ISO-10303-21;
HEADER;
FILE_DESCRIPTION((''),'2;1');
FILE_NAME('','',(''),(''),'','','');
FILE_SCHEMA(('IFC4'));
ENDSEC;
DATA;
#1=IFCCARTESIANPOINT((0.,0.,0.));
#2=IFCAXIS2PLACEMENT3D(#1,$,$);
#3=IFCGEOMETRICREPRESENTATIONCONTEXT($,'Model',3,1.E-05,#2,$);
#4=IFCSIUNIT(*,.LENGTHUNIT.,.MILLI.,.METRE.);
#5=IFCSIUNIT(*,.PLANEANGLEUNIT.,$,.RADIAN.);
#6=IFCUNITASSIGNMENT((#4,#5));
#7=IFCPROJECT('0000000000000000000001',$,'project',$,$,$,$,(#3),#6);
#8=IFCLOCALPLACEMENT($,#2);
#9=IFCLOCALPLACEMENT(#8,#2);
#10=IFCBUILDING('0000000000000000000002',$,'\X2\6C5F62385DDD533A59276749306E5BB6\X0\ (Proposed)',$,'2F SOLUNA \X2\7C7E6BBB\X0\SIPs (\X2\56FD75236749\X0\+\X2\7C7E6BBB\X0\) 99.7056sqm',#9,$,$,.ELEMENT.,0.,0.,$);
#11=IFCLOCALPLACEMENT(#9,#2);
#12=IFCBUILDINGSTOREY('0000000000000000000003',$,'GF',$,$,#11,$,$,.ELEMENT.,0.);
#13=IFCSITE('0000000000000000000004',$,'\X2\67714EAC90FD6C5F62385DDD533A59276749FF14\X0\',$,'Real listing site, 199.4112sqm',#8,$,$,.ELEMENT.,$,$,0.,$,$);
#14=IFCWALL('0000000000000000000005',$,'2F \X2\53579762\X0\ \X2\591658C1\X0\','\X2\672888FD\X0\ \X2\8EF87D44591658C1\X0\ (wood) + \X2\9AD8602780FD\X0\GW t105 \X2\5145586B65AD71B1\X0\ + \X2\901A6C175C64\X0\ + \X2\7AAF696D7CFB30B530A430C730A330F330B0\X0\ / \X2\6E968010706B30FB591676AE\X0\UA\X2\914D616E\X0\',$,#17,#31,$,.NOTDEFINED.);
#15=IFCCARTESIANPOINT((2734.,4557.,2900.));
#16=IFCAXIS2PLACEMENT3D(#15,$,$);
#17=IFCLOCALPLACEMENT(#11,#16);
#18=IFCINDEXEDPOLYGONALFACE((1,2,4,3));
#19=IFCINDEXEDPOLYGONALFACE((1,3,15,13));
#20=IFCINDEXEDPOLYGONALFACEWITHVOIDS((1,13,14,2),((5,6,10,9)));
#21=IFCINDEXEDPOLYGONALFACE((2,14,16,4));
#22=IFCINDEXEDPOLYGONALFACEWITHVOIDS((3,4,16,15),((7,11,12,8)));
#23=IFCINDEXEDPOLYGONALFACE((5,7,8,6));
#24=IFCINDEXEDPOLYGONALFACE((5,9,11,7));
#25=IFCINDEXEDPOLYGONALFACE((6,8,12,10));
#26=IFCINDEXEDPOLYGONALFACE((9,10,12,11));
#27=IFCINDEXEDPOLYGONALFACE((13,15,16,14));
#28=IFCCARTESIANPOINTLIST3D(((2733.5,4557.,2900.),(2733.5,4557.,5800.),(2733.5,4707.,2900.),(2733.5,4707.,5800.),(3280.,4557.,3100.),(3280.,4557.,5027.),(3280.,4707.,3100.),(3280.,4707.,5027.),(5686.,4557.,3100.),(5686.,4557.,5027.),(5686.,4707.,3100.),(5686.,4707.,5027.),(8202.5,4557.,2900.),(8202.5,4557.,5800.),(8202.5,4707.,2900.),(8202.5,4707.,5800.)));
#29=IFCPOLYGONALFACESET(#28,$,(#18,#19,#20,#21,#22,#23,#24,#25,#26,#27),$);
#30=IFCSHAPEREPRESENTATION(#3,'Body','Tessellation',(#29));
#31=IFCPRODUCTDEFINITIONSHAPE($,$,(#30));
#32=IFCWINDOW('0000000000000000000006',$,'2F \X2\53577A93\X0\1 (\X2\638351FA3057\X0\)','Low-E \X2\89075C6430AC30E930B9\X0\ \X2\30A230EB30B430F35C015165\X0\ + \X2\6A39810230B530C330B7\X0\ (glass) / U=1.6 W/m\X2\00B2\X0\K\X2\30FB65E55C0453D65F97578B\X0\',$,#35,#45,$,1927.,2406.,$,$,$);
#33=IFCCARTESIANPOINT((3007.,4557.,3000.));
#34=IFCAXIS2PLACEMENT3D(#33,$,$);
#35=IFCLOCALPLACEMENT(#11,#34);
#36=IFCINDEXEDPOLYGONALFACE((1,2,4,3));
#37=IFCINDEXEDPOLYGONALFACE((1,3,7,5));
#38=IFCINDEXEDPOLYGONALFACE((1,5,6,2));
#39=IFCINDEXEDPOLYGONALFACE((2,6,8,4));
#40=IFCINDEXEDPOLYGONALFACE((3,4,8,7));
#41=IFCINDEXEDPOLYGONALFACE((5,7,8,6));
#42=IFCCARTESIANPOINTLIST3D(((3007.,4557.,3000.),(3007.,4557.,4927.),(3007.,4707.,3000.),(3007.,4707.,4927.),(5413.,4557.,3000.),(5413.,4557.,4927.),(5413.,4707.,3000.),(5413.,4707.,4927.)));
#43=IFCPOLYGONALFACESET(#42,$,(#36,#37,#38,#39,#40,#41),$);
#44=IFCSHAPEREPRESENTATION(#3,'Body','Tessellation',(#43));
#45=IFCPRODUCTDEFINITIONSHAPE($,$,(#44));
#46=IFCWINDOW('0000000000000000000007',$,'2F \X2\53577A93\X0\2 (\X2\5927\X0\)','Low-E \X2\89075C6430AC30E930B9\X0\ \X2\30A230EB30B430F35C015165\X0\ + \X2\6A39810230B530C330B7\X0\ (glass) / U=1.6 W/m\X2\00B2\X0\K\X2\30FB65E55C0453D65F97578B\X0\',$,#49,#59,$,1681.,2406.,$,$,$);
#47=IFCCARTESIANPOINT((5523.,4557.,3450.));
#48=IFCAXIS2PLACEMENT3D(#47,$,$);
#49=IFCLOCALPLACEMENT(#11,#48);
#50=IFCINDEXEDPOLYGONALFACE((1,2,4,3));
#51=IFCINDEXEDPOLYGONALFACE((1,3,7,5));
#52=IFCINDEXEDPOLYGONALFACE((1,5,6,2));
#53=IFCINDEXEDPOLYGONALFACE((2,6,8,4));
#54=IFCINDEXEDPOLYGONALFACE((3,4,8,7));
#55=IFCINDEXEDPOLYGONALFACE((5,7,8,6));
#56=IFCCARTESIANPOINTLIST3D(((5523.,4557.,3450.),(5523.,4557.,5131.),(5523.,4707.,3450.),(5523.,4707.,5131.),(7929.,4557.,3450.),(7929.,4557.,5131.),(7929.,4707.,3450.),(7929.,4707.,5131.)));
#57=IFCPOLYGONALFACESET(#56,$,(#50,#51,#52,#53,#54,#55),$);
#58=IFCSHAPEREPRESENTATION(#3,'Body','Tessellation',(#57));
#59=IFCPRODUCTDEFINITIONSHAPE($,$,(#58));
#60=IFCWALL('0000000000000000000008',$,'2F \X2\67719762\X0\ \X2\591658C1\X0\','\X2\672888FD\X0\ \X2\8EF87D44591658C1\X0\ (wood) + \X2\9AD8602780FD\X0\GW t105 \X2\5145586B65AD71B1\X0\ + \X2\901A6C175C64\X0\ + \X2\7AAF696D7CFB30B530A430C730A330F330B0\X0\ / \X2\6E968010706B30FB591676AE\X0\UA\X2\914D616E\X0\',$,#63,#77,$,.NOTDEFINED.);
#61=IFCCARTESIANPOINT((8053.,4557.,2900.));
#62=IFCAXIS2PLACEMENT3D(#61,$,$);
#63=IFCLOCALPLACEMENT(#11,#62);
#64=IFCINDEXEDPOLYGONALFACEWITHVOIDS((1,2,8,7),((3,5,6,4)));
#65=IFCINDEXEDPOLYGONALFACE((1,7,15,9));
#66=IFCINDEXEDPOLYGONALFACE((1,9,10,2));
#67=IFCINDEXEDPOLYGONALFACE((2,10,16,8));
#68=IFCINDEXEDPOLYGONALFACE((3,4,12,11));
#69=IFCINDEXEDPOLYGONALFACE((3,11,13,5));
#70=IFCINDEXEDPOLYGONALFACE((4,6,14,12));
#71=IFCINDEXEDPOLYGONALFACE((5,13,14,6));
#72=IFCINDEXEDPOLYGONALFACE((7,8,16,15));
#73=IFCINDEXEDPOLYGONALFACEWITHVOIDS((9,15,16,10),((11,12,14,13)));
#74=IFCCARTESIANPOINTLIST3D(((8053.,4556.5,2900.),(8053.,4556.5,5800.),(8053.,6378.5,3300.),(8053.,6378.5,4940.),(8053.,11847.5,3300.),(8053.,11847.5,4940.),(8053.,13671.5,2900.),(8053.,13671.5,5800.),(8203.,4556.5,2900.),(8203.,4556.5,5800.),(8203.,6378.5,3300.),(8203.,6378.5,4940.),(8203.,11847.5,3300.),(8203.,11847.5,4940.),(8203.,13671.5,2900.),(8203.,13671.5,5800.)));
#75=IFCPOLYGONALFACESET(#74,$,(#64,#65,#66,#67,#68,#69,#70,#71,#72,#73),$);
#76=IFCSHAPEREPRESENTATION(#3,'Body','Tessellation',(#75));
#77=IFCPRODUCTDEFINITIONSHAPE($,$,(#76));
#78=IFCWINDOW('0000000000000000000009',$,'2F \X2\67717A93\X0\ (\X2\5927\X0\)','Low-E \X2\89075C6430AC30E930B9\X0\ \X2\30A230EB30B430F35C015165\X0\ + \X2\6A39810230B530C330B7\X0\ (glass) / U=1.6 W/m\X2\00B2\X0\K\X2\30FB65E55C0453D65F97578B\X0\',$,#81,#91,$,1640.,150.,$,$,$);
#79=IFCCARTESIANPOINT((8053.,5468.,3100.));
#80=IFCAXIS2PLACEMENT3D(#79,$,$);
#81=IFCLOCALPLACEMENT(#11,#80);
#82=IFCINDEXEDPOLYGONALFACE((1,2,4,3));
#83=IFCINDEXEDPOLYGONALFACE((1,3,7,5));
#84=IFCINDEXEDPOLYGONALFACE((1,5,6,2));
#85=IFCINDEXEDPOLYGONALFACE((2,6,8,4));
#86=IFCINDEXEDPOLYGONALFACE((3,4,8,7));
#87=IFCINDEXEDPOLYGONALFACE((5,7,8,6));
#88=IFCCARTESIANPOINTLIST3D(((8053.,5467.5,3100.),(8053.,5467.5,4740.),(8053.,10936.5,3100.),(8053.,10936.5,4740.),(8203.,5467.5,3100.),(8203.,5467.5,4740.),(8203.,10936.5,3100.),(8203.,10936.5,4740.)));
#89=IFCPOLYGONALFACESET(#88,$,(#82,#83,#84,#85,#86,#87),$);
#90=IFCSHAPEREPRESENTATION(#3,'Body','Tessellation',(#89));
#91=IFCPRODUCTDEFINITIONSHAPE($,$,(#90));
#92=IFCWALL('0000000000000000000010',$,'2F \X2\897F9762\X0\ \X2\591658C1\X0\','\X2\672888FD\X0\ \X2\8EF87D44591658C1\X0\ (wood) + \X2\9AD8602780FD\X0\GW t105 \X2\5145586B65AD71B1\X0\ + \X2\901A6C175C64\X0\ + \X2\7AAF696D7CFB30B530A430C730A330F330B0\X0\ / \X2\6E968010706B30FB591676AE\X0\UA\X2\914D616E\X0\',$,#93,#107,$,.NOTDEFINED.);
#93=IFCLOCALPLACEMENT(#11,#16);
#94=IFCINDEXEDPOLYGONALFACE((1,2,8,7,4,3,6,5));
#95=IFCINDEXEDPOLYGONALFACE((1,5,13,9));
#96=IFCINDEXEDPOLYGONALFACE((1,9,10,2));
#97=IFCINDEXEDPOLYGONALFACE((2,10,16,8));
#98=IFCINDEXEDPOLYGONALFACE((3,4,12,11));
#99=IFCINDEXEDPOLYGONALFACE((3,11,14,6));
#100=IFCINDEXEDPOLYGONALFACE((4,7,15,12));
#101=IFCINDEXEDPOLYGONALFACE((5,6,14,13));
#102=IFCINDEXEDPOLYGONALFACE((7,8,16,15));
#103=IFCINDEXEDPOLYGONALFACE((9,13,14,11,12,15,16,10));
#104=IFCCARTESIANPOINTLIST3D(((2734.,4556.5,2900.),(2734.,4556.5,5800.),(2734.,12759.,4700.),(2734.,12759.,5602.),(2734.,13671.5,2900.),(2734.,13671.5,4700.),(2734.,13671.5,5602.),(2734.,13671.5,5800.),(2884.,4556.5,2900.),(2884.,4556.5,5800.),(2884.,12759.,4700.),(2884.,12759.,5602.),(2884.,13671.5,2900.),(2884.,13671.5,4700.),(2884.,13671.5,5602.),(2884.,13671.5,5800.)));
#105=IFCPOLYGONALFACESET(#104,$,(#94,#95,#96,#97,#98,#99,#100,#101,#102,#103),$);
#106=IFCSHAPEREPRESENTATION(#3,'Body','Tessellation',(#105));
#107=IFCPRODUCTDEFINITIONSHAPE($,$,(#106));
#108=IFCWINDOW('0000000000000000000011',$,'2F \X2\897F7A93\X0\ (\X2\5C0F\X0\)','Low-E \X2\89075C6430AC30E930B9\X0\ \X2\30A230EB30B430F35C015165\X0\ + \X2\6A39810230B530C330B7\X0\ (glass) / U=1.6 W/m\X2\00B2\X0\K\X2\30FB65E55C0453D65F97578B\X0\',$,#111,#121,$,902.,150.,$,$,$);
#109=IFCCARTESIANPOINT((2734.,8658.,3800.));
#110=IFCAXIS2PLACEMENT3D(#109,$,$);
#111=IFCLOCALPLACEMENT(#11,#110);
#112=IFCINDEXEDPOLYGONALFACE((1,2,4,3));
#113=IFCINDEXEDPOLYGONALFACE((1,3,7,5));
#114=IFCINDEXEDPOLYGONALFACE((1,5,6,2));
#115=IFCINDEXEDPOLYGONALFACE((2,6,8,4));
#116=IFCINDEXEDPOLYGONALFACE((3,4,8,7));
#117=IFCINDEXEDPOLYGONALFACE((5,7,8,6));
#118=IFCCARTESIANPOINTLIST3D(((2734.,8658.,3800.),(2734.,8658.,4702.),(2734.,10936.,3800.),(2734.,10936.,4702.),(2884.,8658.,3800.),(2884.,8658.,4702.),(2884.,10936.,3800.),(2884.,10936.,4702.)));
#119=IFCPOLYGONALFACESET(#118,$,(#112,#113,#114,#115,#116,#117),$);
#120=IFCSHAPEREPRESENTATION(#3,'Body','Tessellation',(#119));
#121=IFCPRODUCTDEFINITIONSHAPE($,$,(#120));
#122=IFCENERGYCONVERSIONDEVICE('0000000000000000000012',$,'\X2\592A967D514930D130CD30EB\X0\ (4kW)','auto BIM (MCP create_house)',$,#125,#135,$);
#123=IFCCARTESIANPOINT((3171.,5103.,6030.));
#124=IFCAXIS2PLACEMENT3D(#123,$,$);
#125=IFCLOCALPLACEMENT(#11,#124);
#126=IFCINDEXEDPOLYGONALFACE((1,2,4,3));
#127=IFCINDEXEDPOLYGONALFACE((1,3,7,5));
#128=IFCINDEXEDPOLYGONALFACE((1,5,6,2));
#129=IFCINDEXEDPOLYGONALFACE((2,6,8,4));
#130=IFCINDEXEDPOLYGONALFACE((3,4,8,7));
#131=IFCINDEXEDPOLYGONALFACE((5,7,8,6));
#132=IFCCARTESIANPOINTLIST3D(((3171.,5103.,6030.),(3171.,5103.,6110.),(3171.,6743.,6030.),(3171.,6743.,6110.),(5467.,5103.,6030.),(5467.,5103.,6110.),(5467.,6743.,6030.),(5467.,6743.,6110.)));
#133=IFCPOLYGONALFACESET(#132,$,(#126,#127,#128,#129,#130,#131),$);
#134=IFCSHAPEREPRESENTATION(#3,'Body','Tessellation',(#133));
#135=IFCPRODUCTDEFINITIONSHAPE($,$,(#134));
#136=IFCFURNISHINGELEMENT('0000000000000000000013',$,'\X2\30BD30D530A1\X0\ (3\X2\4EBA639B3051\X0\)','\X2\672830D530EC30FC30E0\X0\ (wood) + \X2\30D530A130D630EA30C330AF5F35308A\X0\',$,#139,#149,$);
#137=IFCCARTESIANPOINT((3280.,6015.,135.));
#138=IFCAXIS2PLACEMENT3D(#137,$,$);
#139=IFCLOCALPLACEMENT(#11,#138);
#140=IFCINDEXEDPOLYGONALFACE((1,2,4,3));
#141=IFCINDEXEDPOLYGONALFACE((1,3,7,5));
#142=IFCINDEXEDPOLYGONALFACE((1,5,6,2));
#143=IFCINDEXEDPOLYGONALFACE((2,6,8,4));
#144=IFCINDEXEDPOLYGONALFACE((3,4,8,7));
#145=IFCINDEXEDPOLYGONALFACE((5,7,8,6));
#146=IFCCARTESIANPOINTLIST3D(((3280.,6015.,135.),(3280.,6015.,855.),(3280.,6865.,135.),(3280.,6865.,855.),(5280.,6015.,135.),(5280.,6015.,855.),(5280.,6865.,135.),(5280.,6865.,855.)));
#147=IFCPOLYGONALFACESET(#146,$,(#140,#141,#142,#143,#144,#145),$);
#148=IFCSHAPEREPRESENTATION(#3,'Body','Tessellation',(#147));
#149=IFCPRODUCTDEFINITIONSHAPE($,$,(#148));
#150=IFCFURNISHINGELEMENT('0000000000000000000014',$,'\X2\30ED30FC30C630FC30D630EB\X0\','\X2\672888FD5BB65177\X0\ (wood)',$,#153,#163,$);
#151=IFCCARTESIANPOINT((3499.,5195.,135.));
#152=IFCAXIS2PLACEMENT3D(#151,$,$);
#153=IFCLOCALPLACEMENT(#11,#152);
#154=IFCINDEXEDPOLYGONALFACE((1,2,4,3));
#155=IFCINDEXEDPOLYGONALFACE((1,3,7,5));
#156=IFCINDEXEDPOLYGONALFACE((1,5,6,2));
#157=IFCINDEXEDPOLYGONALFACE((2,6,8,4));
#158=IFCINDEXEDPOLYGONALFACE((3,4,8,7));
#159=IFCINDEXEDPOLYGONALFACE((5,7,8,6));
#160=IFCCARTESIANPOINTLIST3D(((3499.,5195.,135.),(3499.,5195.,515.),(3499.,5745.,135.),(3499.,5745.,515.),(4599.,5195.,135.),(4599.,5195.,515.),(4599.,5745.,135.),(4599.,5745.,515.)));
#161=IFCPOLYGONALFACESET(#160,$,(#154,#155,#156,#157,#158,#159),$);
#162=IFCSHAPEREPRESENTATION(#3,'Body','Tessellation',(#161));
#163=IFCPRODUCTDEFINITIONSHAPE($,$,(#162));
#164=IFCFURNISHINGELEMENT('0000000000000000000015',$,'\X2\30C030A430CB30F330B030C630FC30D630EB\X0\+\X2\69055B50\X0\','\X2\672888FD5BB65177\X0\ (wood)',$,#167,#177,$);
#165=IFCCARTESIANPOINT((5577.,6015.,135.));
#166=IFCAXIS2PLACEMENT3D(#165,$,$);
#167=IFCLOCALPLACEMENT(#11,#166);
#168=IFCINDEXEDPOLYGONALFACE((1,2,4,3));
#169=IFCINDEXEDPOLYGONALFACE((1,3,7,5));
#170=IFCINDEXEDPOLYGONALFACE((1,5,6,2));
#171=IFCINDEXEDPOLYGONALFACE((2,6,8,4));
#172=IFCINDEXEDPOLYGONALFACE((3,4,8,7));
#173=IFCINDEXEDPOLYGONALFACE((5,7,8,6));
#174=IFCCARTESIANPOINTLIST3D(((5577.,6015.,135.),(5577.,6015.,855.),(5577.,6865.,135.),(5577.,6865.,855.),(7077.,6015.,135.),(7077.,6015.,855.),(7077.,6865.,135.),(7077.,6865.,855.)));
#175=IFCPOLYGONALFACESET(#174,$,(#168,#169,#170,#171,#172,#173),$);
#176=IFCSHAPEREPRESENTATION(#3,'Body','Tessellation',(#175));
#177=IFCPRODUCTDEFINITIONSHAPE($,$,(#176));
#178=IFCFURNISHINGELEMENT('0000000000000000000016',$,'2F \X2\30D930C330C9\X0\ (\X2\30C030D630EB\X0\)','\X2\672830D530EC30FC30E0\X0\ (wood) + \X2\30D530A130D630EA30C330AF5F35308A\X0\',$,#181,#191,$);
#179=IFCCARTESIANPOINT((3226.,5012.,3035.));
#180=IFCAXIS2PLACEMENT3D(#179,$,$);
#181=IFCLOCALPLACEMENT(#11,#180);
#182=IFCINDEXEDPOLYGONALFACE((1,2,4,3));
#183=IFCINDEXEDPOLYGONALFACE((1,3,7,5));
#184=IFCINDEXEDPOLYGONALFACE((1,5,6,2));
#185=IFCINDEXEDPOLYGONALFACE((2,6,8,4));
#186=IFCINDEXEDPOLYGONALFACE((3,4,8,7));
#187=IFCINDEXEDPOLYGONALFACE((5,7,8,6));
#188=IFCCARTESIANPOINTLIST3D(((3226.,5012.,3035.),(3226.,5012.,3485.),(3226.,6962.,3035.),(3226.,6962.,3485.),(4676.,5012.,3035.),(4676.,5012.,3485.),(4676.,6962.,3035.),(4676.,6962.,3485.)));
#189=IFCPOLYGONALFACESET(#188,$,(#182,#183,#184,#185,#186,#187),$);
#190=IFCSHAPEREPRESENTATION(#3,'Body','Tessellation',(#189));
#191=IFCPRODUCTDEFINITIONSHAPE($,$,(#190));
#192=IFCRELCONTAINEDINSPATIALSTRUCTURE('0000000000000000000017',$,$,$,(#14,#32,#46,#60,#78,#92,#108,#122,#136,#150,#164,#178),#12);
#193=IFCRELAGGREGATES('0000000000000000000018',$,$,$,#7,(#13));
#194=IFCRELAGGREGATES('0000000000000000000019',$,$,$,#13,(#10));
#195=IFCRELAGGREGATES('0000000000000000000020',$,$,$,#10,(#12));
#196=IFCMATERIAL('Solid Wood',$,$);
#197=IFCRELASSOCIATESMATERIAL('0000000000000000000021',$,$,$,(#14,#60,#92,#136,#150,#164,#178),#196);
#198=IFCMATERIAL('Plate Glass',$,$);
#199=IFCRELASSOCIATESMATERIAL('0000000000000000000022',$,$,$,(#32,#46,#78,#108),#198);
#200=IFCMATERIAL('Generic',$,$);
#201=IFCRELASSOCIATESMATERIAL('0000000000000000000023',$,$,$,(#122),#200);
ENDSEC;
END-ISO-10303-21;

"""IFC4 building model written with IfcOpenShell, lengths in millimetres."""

from ifc_helpers import new_model, si_unit, frame, frame_2d, origin, place, context, project, spatial, rectangle, extrude, material, element, fill, save


model = new_model("IFC4")

# Units and contexts
model_context = context("Model", 3, precision=1e-05, world=origin())
ifc_project = project(units=[si_unit("LENGTHUNIT", "METRE", prefix="MILLI"), si_unit("PLANEANGLEUNIT", "RADIAN")], contexts=[model_context])

# Site, building, storey
site_placement = place(None, origin())
site = spatial("IfcSite", under=ifc_project, at=site_placement, Name="東京都江戸川区大杉４", ObjectType="Real listing site, 199.4112sqm", CompositionType="ELEMENT", RefElevation=0.0)
building_placement = place(site_placement, origin())
building = spatial("IfcBuilding", under=site, at=building_placement, Name="江戸川区大杉の家 (Proposed)", ObjectType="2F SOLUNA 籾殻SIPs (国産杉+籾殻) 99.7056sqm", CompositionType="ELEMENT", ElevationOfRefHeight=0.0, ElevationOfTerrain=0.0)
storey_placement = place(building_placement, origin())
storey = spatial("IfcBuildingStorey", under=building, at=storey_placement, Name="GF", CompositionType="ELEMENT", Elevation=0.0)

# Shared definitions
ifc_material_1 = material(Name="Solid Wood")

# Wall, openings, windows
wall_1_placement = place(storey_placement, frame((2734.0, 4557.0, 2900.0)))
wall_1 = element("IfcWall", 1, at=wall_1_placement, inside=storey, material=ifc_material_1, Name="2F 南面 外壁", Description="木製 軸組外壁 (wood) + 高性能GW t105 充填断熱 + 通気層 + 窯業系サイディング / 準耐火・外皮UA配慮", PredefinedType="NOTDEFINED", context=model_context, shape_type="SweptSolid", body=[
    extrude(rectangle(XDim=5469.0, YDim=150.0, at=frame_2d((2734.0, 75.0))), frame((2734.0, 4557.0, 2900.0)), (0.0, 0.0, 1.0), 2900.0),
])
opening_1_placement = place(storey_placement, frame((3007.0, 4557.0, 3000.0)))
opening_1 = element("IfcOpeningElement", 2, at=opening_1_placement, cuts=wall_1, PredefinedType="NOTDEFINED", context=model_context, shape_type="SweptSolid", body=[
    extrude(rectangle(XDim=2406.0, YDim=150.0, at=frame_2d((1203.0, 75.0))), frame((3007.0, 4557.0, 3000.0)), (0.0, 0.0, 1.0), 1927.0),
])
opening_2_placement = place(storey_placement, frame((5523.0, 4557.0, 3450.0)))
opening_2 = element("IfcOpeningElement", 3, at=opening_2_placement, cuts=wall_1, PredefinedType="NOTDEFINED", context=model_context, shape_type="SweptSolid", body=[
    extrude(rectangle(XDim=2406.0, YDim=150.0, at=frame_2d((1203.0, 75.0))), frame((5523.0, 4557.0, 3450.0)), (0.0, 0.0, 1.0), 1681.0),
])
ifc_material_2 = material(Name="Plate Glass")
window_1_placement = place(storey_placement, frame((3007.0, 4557.0, 3000.0)))
window_1 = element("IfcWindow", 4, at=window_1_placement, inside=storey, material=ifc_material_2, Name="2F 南窓1 (掃出し)", Description="Low-E 複層ガラス アルゴン封入 + 樹脂サッシ (glass) / U=1.6 W/m²K・日射取得型", OverallHeight=1927.0, OverallWidth=2406.0, context=model_context, shape_type="SweptSolid", body=[
    extrude(rectangle(XDim=2406.0, YDim=150.0, at=frame_2d((1203.0, 75.0))), frame((3007.0, 4557.0, 3000.0)), (0.0, 0.0, 1.0), 1927.0),
])
fill(opening_1, window_1)
window_2_placement = place(storey_placement, frame((5523.0, 4557.0, 3450.0)))
window_2 = element("IfcWindow", 5, at=window_2_placement, inside=storey, material=ifc_material_2, Name="2F 南窓2 (大)", Description="Low-E 複層ガラス アルゴン封入 + 樹脂サッシ (glass) / U=1.6 W/m²K・日射取得型", OverallHeight=1681.0, OverallWidth=2406.0, context=model_context, shape_type="SweptSolid", body=[
    extrude(rectangle(XDim=2406.0, YDim=150.0, at=frame_2d((1203.0, 75.0))), frame((5523.0, 4557.0, 3450.0)), (0.0, 0.0, 1.0), 1681.0),
])
fill(opening_2, window_2)

# Walls, openings, windows
wall_2_placement = place(storey_placement, frame((8053.0, 4557.0, 2900.0)))
wall_2 = element("IfcWall", 6, at=wall_2_placement, inside=storey, material=ifc_material_1, Name="2F 東面 外壁", Description="木製 軸組外壁 (wood) + 高性能GW t105 充填断熱 + 通気層 + 窯業系サイディング / 準耐火・外皮UA配慮", PredefinedType="NOTDEFINED", context=model_context, shape_type="SweptSolid", body=[
    extrude(rectangle(XDim=150.0, YDim=9115.0, at=frame_2d((75.0, 4557.0))), frame((8053.0, 4557.0, 2900.0)), (0.0, 0.0, 1.0), 2900.0),
])
opening_3_placement = place(storey_placement, frame((8053.0, 5468.0, 3100.0)))
opening_3 = element("IfcOpeningElement", 7, at=opening_3_placement, cuts=wall_2, PredefinedType="NOTDEFINED", context=model_context, shape_type="SweptSolid", body=[
    extrude(rectangle(XDim=150.0, YDim=5469.0, at=frame_2d((75.0, 2734.0))), frame((8053.0, 5468.0, 3100.0)), (0.0, 0.0, 1.0), 1640.0),
])
window_3_placement = place(storey_placement, frame((8053.0, 5468.0, 3100.0)))
window_3 = element("IfcWindow", 8, at=window_3_placement, inside=storey, material=ifc_material_2, Name="2F 東窓 (大)", Description="Low-E 複層ガラス アルゴン封入 + 樹脂サッシ (glass) / U=1.6 W/m²K・日射取得型", OverallHeight=1640.0, OverallWidth=150.0, context=model_context, shape_type="SweptSolid", body=[
    extrude(rectangle(XDim=150.0, YDim=5469.0, at=frame_2d((75.0, 2734.0))), frame((8053.0, 5468.0, 3100.0)), (0.0, 0.0, 1.0), 1640.0),
])
fill(opening_3, window_3)
wall_3_placement = place(storey_placement, frame((2734.0, 4557.0, 2900.0)))
wall_3 = element("IfcWall", 9, at=wall_3_placement, inside=storey, material=ifc_material_1, Name="2F 西面 外壁", Description="木製 軸組外壁 (wood) + 高性能GW t105 充填断熱 + 通気層 + 窯業系サイディング / 準耐火・外皮UA配慮", PredefinedType="NOTDEFINED", context=model_context, shape_type="SweptSolid", body=[
    extrude(rectangle(XDim=150.0, YDim=9115.0, at=frame_2d((75.0, 4557.0))), frame((2734.0, 4557.0, 2900.0)), (0.0, 0.0, 1.0), 2900.0),
])
opening_4_placement = place(storey_placement, frame((2734.0, 8658.0, 3800.0)))
opening_4 = element("IfcOpeningElement", 10, at=opening_4_placement, cuts=wall_3, PredefinedType="NOTDEFINED", context=model_context, shape_type="SweptSolid", body=[
    extrude(rectangle(XDim=150.0, YDim=2278.0, at=frame_2d((75.0, 1139.0))), frame((2734.0, 8658.0, 3800.0)), (0.0, 0.0, 1.0), 902.0),
])
window_4_placement = place(storey_placement, frame((2734.0, 8658.0, 3800.0)))
window_4 = element("IfcWindow", 11, at=window_4_placement, inside=storey, material=ifc_material_2, Name="2F 西窓 (小)", Description="Low-E 複層ガラス アルゴン封入 + 樹脂サッシ (glass) / U=1.6 W/m²K・日射取得型", OverallHeight=902.0, OverallWidth=150.0, context=model_context, shape_type="SweptSolid", body=[
    extrude(rectangle(XDim=150.0, YDim=2278.0, at=frame_2d((75.0, 1139.0))), frame((2734.0, 8658.0, 3800.0)), (0.0, 0.0, 1.0), 902.0),
])
fill(opening_4, window_4)

# Shared definitions
ifc_material_3 = material(Name="Generic")

# Energy conversion device
energy_conversion_device_placement = place(storey_placement, frame((3171.0, 5103.0, 6030.0)))
element("IfcEnergyConversionDevice", 12, at=energy_conversion_device_placement, inside=storey, material=ifc_material_3, Name="太陽光パネル (4kW)", Description="auto BIM (MCP create_house)", context=model_context, shape_type="SweptSolid", body=[
    extrude(rectangle(XDim=2296.0, YDim=1640.0, at=frame_2d((1148.0, 820.0))), frame((3171.0, 5103.0, 6030.0)), (0.0, 0.0, 1.0), 80.0),
])

# Furnishing elements
furnishing_1_placement = place(storey_placement, frame((3280.0, 6015.0, 135.0)))
element("IfcFurnishingElement", 13, at=furnishing_1_placement, inside=storey, material=ifc_material_1, Name="ソファ (3人掛け)", Description="木フレーム (wood) + ファブリック張り", context=model_context, shape_type="SweptSolid", body=[
    extrude(rectangle(XDim=2000.0, YDim=850.0, at=frame_2d((1000.0, 425.0))), frame((3280.0, 6015.0, 135.0)), (0.0, 0.0, 1.0), 720.0),
])
furnishing_2_placement = place(storey_placement, frame((3499.0, 5195.0, 135.0)))
element("IfcFurnishingElement", 14, at=furnishing_2_placement, inside=storey, material=ifc_material_1, Name="ローテーブル", Description="木製家具 (wood)", context=model_context, shape_type="SweptSolid", body=[
    extrude(rectangle(XDim=1100.0, YDim=550.0, at=frame_2d((550.0, 275.0))), frame((3499.0, 5195.0, 135.0)), (0.0, 0.0, 1.0), 380.0),
])
furnishing_3_placement = place(storey_placement, frame((5577.0, 6015.0, 135.0)))
element("IfcFurnishingElement", 15, at=furnishing_3_placement, inside=storey, material=ifc_material_1, Name="ダイニングテーブル+椅子", Description="木製家具 (wood)", context=model_context, shape_type="SweptSolid", body=[
    extrude(rectangle(XDim=1500.0, YDim=850.0, at=frame_2d((750.0, 425.0))), frame((5577.0, 6015.0, 135.0)), (0.0, 0.0, 1.0), 720.0),
])
furnishing_4_placement = place(storey_placement, frame((3226.0, 5012.0, 3035.0)))
element("IfcFurnishingElement", 16, at=furnishing_4_placement, inside=storey, material=ifc_material_1, Name="2F ベッド (ダブル)", Description="木フレーム (wood) + ファブリック張り", context=model_context, shape_type="SweptSolid", body=[
    extrude(rectangle(XDim=1450.0, YDim=1950.0, at=frame_2d((725.0, 975.0))), frame((3226.0, 5012.0, 3035.0)), (0.0, 0.0, 1.0), 450.0),
])

save(model, "model.ifc")
